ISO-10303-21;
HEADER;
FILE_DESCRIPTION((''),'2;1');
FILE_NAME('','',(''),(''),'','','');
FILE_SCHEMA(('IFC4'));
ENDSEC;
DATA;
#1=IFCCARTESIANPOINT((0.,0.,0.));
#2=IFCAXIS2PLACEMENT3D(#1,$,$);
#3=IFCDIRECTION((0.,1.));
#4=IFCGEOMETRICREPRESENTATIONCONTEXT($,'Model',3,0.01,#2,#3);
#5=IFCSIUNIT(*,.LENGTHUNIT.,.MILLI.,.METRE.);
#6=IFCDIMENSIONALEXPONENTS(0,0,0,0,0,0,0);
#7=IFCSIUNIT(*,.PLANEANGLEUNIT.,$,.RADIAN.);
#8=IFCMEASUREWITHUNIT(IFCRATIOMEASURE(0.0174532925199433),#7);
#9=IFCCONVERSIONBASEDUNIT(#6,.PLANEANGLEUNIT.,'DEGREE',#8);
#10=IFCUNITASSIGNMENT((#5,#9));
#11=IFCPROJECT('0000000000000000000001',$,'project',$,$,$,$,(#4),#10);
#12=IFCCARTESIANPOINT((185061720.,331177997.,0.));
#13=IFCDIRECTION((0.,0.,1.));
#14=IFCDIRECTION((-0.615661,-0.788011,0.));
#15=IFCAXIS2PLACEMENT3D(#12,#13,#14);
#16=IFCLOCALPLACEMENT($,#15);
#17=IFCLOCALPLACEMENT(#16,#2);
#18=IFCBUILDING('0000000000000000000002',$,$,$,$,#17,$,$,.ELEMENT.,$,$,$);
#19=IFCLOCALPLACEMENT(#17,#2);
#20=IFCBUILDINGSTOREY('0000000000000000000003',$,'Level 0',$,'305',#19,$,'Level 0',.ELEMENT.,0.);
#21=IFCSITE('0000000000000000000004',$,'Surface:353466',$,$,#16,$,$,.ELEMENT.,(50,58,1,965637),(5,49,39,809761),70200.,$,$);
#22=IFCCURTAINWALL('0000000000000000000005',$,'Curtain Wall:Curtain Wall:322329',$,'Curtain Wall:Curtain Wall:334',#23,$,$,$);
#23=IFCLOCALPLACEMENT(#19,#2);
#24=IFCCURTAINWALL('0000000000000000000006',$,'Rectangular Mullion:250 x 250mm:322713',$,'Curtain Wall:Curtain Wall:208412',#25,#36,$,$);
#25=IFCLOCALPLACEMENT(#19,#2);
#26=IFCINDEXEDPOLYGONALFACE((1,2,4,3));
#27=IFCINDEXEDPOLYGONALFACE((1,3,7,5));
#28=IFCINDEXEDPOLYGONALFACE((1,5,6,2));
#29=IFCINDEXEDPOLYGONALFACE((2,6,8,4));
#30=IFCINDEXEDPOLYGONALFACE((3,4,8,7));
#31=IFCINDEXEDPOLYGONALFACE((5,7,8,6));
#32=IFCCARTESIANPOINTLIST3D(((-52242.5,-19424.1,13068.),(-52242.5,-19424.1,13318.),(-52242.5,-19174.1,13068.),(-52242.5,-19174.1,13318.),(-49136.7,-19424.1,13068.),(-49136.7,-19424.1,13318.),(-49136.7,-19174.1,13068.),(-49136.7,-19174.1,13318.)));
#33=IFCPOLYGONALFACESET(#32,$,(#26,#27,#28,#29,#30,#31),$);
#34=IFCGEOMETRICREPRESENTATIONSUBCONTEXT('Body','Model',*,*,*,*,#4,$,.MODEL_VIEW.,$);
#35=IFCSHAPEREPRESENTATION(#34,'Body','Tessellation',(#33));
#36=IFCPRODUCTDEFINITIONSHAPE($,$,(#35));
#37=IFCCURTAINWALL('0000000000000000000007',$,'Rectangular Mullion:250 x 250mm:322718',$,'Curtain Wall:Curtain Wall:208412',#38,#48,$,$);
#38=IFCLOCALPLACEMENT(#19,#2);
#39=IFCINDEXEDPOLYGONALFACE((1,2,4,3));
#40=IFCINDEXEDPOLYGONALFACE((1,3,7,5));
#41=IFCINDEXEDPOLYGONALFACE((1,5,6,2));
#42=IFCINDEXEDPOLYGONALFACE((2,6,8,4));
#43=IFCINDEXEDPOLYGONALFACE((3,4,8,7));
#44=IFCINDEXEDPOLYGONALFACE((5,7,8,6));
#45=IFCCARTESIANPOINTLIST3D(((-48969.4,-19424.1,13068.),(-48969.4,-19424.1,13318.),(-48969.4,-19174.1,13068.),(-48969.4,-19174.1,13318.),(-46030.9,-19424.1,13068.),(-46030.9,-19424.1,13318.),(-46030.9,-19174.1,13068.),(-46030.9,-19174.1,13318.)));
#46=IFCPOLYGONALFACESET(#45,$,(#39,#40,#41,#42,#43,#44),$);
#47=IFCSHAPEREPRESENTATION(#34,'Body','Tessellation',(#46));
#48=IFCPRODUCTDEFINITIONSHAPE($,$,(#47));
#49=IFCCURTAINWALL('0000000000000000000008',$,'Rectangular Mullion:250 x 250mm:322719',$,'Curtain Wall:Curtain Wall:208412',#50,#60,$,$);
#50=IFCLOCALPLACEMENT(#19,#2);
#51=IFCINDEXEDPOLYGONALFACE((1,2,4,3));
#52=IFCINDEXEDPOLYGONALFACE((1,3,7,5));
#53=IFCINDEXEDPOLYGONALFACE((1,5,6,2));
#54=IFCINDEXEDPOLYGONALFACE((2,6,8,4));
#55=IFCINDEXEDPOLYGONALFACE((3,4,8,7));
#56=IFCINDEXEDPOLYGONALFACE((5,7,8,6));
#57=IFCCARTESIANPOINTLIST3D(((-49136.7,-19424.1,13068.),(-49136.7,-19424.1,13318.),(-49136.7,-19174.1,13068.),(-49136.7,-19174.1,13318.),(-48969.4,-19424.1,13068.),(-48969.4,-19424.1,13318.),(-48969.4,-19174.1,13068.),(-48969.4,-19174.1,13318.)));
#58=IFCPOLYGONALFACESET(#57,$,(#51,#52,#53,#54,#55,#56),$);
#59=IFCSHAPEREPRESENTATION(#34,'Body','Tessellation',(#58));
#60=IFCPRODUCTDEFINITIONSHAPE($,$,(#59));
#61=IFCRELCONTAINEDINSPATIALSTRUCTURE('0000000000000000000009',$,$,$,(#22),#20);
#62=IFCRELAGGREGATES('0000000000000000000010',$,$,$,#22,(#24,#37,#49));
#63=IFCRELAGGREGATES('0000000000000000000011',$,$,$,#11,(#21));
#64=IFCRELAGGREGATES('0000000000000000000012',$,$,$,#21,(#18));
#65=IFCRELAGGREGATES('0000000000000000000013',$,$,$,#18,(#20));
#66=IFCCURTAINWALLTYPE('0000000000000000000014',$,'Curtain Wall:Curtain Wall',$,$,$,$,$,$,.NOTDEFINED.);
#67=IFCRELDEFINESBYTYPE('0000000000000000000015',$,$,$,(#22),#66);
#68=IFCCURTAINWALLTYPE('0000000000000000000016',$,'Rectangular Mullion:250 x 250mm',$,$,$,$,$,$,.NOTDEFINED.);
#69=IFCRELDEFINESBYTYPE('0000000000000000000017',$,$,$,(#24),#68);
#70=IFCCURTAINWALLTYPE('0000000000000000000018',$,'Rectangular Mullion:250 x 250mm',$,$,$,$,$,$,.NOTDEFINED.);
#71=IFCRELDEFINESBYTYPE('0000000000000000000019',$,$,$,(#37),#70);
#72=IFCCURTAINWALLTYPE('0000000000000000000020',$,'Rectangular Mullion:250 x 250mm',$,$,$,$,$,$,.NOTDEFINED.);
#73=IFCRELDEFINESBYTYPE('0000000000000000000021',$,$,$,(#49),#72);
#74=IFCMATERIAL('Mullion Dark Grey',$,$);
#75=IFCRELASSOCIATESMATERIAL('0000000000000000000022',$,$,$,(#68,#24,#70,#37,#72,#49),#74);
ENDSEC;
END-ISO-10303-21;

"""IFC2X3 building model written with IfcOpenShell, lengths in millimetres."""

from ifc_helpers import new_model, entity, si_unit, converted_unit, direction, frame, origin, origin_2d_with_axis, place, context, subcontext, project, spatial, rectangle, extrude, source, transform, mapped, material, type_object, type_shapes, element, aggregate, save


model = new_model("IFC2X3")

# Units and contexts
model_context = context("Model", 3, precision=0.01, world=origin(), true_north=direction((0.0, 1.0)))
body_context = subcontext(model_context, "Body", "Model", "MODEL_VIEW")
ifc_project = project(units=[si_unit("LENGTHUNIT", "METRE", prefix="MILLI"), converted_unit("PLANEANGLEUNIT", "DEGREE", entity("IfcRatioMeasure", 0.0174532925199433), si_unit("PLANEANGLEUNIT", "RADIAN"), dimensions=[0, 0, 0, 0, 0, 0, 0])], contexts=[model_context])

# Site, building, storey
site_placement = place(None, frame((185061720.0, 331177997.0, 0.0), z_axis=(0.0, 0.0, 1.0), x_axis=(-0.615661, -0.788011, 0.0)))
site = spatial("IfcSite", under=ifc_project, at=site_placement, Name="Surface:353466", CompositionType="ELEMENT", RefLatitude=(50, 58, 1, 965637), RefLongitude=(5, 49, 39, 809761), RefElevation=70200.0)
building_placement = place(site_placement, origin())
building = spatial("IfcBuilding", under=site, at=building_placement, CompositionType="ELEMENT")
storey_placement = place(building_placement, origin())
storey = spatial("IfcBuildingStorey", under=building, at=storey_placement, Name="Level 0", ObjectType="305", LongName="Level 0", CompositionType="ELEMENT", Elevation=0.0)

# Curtain walls
curtain_wall_type_1 = type_object("IfcCurtainWallType", Name="Curtain Wall:Curtain Wall", PredefinedType="NOTDEFINED")
curtain_wall_1_placement = place(storey_placement, origin())
curtain_wall_1 = element("IfcCurtainWall", 1, at=curtain_wall_1_placement, inside=storey, type_object=curtain_wall_type_1, Name="Curtain Wall:Curtain Wall:322329", ObjectType="Curtain Wall:Curtain Wall:334")
ifc_material_1 = material(Name="Mullion Dark Grey")
curtain_wall_type_2 = type_object("IfcCurtainWallType", Name="Rectangular Mullion:250 x 250mm", PredefinedType="NOTDEFINED", material=ifc_material_1)
shared_shape_1 = source(origin(), body_context, "Body", "SweptSolid", [
    extrude(rectangle(XDim=250.0, YDim=250.0, at=origin_2d_with_axis()), frame((-125.0, 0.0, -3105.8), z_axis=(0.0, 0.0, 1.0), x_axis=(-1.0, 0.0, 0.0)), (0.0, 0.0, 1.0), 3105.8),
])
type_shapes(curtain_wall_type_2, [shared_shape_1])
curtain_wall_2_placement = place(storey_placement, frame((-52242.5, -19299.1, 13318.0), z_axis=(-1.0, 0.0, 0.0), x_axis=(0.0, 0.0, 1.0)))
curtain_wall_2 = element("IfcCurtainWall", 2, at=curtain_wall_2_placement, type_object=curtain_wall_type_2, material=ifc_material_1, Name="Rectangular Mullion:250 x 250mm:322713", ObjectType="Curtain Wall:Curtain Wall:208412", context=body_context, shape_type="MappedRepresentation", body=[
    mapped(shared_shape_1, transform((0.0, 0.0, 0.0), scale=1.0)),
])
curtain_wall_type_3 = type_object("IfcCurtainWallType", Name="Rectangular Mullion:250 x 250mm", PredefinedType="NOTDEFINED", material=ifc_material_1)
shared_shape_2 = source(origin(), body_context, "Body", "SweptSolid", [
    extrude(rectangle(XDim=250.0, YDim=250.0, at=origin_2d_with_axis()), frame((-125.0, 0.0, -2938.5), z_axis=(0.0, 0.0, 1.0), x_axis=(-1.0, 0.0, 0.0)), (0.0, 0.0, 1.0), 2938.5),
])
type_shapes(curtain_wall_type_3, [shared_shape_2])
curtain_wall_3_placement = place(storey_placement, frame((-48969.4, -19299.1, 13318.0), z_axis=(-1.0, 0.0, 0.0), x_axis=(0.0, 0.0, 1.0)))
curtain_wall_3 = element("IfcCurtainWall", 3, at=curtain_wall_3_placement, type_object=curtain_wall_type_3, material=ifc_material_1, Name="Rectangular Mullion:250 x 250mm:322718", ObjectType="Curtain Wall:Curtain Wall:208412", context=body_context, shape_type="MappedRepresentation", body=[
    mapped(shared_shape_2, transform((0.0, 0.0, 0.0), scale=1.0)),
])
curtain_wall_type_4 = type_object("IfcCurtainWallType", Name="Rectangular Mullion:250 x 250mm", PredefinedType="NOTDEFINED", material=ifc_material_1)
shared_shape_3 = source(origin(), body_context, "Body", "SweptSolid", [
    extrude(rectangle(XDim=250.0, YDim=250.0, at=origin_2d_with_axis()), frame((-125.0, 0.0, -167.3), z_axis=(0.0, 0.0, 1.0), x_axis=(-1.0, 0.0, 0.0)), (0.0, 0.0, 1.0), 167.3),
])
type_shapes(curtain_wall_type_4, [shared_shape_3])
curtain_wall_4_placement = place(storey_placement, frame((-49136.7, -19299.1, 13318.0), z_axis=(-1.0, 0.0, 0.0), x_axis=(0.0, 0.0, 1.0)))
curtain_wall_4 = element("IfcCurtainWall", 4, at=curtain_wall_4_placement, type_object=curtain_wall_type_4, material=ifc_material_1, Name="Rectangular Mullion:250 x 250mm:322719", ObjectType="Curtain Wall:Curtain Wall:208412", context=body_context, shape_type="MappedRepresentation", body=[
    mapped(shared_shape_3, transform((0.0, 0.0, 0.0), scale=1.0)),
])
aggregate(curtain_wall_1, [curtain_wall_2, curtain_wall_3, curtain_wall_4])

save(model, "model.ifc")
